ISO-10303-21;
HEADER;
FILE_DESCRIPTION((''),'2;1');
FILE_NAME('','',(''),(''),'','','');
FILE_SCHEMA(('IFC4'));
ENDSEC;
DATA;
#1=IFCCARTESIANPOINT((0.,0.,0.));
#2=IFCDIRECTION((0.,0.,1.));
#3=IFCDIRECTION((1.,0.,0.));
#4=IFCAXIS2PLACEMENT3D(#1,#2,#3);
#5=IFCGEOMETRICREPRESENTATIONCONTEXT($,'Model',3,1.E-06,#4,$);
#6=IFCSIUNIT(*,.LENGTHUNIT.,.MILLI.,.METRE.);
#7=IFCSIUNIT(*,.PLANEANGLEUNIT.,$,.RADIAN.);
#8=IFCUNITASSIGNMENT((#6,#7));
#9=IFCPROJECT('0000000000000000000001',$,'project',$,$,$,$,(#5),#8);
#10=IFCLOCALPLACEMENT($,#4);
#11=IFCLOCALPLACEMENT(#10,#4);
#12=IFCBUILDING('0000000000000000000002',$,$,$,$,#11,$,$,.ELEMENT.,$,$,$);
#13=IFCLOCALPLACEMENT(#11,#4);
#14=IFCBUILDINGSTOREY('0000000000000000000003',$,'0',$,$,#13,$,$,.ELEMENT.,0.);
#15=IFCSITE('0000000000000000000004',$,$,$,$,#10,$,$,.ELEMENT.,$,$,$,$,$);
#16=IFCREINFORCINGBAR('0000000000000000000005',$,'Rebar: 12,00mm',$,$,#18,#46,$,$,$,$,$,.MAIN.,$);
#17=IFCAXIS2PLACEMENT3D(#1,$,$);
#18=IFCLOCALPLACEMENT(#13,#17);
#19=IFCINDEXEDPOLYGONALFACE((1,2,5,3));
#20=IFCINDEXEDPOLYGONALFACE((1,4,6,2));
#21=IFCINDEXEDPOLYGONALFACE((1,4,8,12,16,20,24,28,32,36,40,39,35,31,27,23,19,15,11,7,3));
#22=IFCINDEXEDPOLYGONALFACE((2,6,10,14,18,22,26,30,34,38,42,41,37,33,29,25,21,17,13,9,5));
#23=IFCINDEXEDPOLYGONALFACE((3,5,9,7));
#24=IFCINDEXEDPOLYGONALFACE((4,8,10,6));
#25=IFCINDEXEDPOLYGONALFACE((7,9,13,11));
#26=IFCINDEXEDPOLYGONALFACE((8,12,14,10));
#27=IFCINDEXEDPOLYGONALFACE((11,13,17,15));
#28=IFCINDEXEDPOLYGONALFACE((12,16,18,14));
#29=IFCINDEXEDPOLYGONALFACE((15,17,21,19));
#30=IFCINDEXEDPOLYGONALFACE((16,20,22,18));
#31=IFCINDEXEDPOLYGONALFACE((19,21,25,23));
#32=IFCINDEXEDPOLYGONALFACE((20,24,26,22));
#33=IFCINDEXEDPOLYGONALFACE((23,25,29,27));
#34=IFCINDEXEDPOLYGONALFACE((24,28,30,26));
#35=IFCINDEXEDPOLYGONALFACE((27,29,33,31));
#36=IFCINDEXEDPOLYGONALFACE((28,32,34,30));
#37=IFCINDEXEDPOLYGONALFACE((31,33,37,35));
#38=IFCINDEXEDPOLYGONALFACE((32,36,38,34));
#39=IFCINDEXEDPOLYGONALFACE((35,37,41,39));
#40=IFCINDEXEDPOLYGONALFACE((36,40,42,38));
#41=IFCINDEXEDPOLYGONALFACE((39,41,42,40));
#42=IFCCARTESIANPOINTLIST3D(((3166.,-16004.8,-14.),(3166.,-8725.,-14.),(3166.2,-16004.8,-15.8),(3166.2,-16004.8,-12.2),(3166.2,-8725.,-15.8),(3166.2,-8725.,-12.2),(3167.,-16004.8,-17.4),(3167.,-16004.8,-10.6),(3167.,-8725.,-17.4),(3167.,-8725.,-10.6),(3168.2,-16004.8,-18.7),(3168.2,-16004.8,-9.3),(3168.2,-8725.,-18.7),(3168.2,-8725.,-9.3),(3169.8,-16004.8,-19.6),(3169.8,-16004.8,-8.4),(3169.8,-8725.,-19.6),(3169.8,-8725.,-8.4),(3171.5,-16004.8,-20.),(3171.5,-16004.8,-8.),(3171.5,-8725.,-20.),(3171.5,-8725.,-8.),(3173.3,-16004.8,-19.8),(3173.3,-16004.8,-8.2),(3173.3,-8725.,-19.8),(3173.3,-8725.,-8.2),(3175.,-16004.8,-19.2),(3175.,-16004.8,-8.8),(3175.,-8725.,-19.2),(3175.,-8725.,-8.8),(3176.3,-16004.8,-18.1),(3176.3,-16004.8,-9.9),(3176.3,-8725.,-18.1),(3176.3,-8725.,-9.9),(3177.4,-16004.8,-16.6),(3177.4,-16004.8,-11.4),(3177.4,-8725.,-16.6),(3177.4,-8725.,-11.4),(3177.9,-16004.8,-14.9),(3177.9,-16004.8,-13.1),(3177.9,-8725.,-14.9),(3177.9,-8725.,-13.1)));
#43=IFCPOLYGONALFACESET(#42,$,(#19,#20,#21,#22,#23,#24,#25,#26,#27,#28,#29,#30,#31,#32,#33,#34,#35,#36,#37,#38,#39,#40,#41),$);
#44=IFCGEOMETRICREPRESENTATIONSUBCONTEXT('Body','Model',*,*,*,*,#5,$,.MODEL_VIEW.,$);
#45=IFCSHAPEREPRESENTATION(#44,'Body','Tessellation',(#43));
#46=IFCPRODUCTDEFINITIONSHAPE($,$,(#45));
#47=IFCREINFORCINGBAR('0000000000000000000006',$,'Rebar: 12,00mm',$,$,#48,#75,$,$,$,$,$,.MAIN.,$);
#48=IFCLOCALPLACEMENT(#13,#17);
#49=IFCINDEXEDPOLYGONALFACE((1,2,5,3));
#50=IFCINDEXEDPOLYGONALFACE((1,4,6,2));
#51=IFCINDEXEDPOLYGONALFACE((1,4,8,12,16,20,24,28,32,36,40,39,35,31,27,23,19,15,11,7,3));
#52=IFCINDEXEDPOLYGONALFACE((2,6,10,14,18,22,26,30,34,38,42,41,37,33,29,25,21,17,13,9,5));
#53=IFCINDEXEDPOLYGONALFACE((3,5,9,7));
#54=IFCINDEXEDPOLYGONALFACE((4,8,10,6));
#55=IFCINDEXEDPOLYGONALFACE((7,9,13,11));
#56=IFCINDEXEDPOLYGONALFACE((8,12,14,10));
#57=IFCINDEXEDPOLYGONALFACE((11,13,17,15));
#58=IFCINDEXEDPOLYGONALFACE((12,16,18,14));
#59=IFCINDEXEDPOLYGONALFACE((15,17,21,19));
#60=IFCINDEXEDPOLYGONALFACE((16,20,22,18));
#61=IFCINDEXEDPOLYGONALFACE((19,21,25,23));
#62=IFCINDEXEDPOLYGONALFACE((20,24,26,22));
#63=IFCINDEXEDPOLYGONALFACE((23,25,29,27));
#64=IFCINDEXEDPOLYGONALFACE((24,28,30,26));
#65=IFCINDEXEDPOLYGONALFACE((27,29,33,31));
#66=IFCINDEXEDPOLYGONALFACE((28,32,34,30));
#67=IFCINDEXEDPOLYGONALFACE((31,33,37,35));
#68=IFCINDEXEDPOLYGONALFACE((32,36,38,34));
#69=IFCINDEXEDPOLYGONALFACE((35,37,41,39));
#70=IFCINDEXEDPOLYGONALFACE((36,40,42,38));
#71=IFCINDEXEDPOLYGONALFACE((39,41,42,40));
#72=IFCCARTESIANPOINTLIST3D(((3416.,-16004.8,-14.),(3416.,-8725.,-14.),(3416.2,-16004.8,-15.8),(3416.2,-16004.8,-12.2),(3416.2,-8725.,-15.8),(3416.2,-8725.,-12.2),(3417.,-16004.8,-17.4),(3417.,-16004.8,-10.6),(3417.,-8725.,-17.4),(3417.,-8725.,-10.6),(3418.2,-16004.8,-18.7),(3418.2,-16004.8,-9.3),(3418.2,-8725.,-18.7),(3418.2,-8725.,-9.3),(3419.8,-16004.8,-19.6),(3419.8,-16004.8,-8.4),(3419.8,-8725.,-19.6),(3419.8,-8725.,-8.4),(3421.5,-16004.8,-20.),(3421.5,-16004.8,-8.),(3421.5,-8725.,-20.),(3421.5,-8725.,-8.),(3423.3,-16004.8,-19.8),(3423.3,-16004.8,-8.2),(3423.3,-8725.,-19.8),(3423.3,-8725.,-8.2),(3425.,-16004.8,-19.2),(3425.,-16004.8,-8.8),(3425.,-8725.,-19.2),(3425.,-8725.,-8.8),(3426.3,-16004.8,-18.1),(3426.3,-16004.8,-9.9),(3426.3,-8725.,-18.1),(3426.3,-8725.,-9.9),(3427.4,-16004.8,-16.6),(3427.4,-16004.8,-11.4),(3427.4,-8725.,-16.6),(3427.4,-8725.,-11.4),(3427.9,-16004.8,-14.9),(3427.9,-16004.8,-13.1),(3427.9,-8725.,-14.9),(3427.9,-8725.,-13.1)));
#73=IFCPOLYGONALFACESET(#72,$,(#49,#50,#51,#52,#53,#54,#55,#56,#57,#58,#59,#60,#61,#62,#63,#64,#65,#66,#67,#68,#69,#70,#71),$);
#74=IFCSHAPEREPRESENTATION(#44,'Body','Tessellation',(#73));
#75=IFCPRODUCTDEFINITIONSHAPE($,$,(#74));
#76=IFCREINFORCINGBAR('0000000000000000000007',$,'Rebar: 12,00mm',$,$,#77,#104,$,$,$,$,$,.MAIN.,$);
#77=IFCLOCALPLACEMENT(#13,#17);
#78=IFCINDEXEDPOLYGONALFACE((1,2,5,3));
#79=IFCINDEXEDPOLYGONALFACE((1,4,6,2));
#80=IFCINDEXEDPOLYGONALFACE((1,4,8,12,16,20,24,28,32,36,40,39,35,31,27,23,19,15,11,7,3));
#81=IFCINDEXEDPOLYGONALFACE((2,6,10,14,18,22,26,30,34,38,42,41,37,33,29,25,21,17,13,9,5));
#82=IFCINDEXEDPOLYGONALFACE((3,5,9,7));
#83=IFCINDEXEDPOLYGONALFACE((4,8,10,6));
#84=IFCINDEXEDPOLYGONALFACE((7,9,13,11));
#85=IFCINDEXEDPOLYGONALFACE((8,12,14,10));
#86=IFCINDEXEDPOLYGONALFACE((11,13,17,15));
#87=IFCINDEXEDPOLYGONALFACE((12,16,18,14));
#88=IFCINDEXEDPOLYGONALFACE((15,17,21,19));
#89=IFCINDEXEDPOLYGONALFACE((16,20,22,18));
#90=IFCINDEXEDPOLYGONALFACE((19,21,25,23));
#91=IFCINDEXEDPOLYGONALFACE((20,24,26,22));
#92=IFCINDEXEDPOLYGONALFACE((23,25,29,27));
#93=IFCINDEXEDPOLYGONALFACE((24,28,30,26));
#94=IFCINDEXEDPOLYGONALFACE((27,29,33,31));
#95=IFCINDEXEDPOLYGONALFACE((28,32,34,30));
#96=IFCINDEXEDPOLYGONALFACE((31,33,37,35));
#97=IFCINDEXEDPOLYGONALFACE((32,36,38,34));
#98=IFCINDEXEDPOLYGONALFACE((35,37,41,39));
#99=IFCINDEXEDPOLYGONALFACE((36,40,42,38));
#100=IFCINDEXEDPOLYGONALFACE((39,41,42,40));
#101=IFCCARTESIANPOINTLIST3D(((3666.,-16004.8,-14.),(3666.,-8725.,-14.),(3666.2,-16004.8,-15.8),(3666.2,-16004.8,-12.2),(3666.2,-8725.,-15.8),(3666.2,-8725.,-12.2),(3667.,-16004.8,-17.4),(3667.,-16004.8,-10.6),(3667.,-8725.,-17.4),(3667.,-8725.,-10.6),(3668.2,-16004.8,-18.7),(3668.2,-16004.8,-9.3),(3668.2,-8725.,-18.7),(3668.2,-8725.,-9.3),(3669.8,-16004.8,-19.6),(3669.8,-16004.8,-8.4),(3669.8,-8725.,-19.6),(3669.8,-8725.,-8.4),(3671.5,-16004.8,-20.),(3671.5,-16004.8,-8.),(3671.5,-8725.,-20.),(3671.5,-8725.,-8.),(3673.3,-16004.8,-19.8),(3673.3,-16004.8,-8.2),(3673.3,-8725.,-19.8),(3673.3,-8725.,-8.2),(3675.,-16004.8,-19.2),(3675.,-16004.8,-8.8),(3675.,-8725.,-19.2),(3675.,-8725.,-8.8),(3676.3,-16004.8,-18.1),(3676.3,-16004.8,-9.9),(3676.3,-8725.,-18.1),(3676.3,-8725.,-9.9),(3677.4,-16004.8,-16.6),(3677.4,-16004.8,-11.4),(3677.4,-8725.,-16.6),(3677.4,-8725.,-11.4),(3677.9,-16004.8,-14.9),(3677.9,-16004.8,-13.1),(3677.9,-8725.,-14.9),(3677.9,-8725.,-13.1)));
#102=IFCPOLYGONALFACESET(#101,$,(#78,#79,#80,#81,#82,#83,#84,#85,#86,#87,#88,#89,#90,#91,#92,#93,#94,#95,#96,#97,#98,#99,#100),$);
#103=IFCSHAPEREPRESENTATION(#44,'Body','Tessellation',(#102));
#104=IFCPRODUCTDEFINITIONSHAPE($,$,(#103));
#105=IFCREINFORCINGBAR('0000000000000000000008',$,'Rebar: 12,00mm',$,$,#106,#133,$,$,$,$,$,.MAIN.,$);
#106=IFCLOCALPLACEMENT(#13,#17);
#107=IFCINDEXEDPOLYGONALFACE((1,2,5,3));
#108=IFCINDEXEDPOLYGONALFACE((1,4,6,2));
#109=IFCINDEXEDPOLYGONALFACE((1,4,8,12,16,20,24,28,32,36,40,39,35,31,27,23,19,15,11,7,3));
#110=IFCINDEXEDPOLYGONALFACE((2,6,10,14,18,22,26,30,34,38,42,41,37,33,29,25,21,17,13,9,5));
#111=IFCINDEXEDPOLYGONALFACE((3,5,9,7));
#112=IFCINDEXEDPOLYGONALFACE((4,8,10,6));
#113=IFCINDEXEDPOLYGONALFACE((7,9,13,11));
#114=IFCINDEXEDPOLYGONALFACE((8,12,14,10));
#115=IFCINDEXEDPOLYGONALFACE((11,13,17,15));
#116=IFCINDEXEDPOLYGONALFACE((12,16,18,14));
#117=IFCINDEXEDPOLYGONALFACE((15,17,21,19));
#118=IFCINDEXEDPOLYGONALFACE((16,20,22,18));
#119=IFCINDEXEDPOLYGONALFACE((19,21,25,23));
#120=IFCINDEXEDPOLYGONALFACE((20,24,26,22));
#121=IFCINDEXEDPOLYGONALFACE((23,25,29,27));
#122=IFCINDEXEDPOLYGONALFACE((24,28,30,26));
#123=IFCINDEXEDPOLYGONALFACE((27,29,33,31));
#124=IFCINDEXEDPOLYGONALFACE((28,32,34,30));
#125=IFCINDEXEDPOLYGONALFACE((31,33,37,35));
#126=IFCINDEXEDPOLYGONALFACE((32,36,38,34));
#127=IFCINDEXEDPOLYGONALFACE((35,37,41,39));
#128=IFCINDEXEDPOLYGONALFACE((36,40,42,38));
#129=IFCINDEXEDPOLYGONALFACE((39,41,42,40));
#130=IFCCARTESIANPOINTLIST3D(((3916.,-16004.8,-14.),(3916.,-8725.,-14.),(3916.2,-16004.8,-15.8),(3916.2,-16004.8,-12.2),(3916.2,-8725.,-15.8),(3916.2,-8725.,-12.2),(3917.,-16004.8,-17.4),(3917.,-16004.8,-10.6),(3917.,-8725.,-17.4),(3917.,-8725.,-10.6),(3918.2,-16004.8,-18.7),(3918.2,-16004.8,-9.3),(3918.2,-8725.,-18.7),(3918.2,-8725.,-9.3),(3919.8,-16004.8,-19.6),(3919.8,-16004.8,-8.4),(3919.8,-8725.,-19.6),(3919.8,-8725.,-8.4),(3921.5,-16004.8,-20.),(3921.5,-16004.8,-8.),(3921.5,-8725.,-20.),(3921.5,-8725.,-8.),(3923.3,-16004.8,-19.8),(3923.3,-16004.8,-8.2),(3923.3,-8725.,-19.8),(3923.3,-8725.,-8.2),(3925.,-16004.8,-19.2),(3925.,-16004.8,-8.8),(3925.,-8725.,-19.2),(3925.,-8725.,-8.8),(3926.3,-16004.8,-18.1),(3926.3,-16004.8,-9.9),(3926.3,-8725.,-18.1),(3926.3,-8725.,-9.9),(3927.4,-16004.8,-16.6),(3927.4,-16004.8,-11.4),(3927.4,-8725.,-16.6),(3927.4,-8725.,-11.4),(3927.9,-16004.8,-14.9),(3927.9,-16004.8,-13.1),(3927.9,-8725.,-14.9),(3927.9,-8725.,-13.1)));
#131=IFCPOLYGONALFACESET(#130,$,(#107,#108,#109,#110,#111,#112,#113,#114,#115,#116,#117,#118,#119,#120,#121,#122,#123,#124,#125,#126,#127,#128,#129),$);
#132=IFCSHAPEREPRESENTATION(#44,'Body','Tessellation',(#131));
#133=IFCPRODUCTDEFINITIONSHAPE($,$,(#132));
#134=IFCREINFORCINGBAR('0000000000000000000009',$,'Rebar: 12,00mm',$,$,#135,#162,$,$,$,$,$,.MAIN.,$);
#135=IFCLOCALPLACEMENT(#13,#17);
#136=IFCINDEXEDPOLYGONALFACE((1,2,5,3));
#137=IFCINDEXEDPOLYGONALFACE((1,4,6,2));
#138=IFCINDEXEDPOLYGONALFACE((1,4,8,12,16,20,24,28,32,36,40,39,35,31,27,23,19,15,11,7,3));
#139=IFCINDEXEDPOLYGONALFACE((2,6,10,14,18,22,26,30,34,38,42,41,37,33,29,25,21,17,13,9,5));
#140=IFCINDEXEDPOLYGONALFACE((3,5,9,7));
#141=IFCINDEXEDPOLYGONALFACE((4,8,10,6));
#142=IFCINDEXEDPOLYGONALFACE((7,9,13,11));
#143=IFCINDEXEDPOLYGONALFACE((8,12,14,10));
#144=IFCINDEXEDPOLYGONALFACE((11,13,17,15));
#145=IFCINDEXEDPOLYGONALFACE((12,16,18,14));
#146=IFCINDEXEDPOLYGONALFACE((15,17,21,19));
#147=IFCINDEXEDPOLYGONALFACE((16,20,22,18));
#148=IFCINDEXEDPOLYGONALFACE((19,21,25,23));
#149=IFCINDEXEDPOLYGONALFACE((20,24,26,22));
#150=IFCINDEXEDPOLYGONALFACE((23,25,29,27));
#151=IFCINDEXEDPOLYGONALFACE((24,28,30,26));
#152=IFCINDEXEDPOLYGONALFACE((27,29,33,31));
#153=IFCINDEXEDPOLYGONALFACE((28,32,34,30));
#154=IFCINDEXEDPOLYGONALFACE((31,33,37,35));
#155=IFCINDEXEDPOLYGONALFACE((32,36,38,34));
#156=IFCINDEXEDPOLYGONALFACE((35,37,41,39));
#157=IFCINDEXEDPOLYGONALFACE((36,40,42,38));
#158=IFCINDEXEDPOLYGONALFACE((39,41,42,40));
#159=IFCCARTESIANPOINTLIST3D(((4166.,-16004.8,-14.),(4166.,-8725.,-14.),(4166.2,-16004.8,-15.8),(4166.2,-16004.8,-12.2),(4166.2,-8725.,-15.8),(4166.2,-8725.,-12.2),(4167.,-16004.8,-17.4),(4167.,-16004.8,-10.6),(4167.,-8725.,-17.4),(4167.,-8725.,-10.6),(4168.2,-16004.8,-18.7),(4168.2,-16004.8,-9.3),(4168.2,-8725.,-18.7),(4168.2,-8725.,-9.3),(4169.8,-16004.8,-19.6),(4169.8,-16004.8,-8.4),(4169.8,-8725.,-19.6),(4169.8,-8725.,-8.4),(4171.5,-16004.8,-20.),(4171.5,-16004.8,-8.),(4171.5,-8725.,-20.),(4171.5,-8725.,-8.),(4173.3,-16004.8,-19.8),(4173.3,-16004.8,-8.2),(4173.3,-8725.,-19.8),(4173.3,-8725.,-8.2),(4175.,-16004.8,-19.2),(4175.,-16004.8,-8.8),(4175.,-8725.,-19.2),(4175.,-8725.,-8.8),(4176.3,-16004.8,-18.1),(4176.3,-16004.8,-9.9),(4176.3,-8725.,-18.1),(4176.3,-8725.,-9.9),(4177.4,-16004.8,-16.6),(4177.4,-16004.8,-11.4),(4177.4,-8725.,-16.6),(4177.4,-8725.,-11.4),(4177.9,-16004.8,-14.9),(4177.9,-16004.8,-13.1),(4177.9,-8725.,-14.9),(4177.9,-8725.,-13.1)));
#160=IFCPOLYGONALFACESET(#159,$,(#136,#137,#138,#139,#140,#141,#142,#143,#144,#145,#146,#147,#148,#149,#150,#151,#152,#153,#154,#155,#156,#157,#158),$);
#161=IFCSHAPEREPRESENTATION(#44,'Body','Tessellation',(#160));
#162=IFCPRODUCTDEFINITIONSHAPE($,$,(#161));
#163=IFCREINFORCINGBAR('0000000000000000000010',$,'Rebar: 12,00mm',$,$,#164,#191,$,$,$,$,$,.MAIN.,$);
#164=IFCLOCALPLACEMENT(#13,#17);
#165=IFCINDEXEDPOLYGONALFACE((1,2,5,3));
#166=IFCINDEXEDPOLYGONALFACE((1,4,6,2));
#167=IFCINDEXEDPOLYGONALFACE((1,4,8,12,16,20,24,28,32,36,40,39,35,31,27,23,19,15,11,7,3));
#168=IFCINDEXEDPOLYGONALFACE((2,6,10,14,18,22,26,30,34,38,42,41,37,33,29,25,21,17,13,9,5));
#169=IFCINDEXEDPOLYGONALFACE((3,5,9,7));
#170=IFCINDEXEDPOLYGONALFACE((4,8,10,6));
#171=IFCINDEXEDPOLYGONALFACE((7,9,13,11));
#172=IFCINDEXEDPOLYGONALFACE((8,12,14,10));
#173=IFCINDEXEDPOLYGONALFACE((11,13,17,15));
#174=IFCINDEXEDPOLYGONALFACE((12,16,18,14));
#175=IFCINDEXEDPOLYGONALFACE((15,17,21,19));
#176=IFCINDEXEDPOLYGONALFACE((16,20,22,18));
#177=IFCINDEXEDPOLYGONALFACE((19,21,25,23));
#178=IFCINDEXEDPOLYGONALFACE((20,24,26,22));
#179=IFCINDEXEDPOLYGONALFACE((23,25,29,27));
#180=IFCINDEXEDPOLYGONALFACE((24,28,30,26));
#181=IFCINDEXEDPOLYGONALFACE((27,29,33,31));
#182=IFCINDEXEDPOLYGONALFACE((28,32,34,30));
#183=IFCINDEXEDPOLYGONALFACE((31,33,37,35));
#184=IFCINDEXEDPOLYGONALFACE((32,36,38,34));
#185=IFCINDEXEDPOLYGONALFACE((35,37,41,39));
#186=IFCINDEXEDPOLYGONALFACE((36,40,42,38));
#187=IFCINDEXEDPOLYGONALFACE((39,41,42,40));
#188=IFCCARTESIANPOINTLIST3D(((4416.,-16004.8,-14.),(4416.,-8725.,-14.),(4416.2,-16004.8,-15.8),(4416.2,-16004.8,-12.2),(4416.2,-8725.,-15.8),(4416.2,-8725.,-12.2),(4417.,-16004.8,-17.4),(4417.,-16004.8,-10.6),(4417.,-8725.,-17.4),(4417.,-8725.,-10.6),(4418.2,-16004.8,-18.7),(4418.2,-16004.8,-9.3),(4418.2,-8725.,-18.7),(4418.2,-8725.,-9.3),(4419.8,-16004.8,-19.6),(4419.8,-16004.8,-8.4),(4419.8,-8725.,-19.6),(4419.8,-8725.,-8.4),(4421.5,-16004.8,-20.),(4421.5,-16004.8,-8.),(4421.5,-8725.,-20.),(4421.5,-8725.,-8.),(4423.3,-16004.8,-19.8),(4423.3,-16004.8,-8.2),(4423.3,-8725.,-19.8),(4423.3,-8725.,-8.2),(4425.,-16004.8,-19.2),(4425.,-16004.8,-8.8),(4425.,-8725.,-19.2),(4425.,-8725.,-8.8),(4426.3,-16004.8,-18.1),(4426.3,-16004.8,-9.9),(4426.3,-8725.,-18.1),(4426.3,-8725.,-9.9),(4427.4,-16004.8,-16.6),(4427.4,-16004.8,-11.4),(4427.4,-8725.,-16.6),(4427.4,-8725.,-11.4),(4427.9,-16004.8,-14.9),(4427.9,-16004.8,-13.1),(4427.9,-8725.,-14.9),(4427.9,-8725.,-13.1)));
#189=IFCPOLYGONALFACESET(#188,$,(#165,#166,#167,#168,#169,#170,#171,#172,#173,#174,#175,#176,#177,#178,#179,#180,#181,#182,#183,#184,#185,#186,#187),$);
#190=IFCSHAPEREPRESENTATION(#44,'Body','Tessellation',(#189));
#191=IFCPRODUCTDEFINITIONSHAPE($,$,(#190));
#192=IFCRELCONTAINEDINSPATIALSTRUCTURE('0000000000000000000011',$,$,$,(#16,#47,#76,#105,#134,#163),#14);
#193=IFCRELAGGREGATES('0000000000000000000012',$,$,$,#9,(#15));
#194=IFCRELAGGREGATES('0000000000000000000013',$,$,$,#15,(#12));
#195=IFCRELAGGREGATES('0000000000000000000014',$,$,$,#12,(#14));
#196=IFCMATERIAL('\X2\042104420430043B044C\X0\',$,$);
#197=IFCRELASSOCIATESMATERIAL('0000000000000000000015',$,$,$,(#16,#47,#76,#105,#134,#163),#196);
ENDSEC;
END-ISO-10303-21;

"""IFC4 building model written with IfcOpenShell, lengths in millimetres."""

from ifc_helpers import new_model, entity, si_unit, origin_with_axes, place, context, subcontext, project, spatial, source, transform, mapped, material, element, save


model = new_model("IFC4")

# Units and contexts
model_context = context("Model", 3, precision=1e-06, world=origin_with_axes())
body_context = subcontext(model_context, "Body", "Model", "MODEL_VIEW")
ifc_project = project(units=[si_unit("LENGTHUNIT", "METRE", prefix="MILLI"), si_unit("PLANEANGLEUNIT", "RADIAN")], contexts=[model_context])

# Site, building, storey
site_placement = place(None, origin_with_axes())
site = spatial("IfcSite", under=ifc_project, at=site_placement, CompositionType="ELEMENT")
building_placement = place(site_placement, origin_with_axes())
building = spatial("IfcBuilding", under=site, at=building_placement, CompositionType="ELEMENT")
storey_placement = place(building_placement, origin_with_axes())
storey = spatial("IfcBuildingStorey", under=building, at=storey_placement, Name="0", CompositionType="ELEMENT", Elevation=0.0)

# Reinforcing bars
ifc_material = material(Name="Сталь")
shared_shape = source(origin_with_axes(), body_context, "Body", "AdvancedSweptSolid", [
    entity("IfcSweptDiskSolid", entity("IfcIndexedPolyCurve", entity("IfcCartesianPointList3D", [[0.0, 0.0, 0.0], [7279.8, 0.0, 0.0]]), [entity("IfcLineIndex", [1, 2])]), 6.0),
])
reinforcing_bar_1_placement = place(storey_placement, origin_with_axes())
element("IfcReinforcingBar", 1, at=reinforcing_bar_1_placement, inside=storey, material=ifc_material, Name="Rebar: 12,00mm", PredefinedType="MAIN", context=body_context, shape_type="MappedRepresentation", body=[
    mapped(shared_shape, transform((3172.0, -16004.8, -14.0), x_axis=(0.0, 1.0, 0.0), y_axis=(-1.0, 0.0, 0.0), z_axis=(0.0, 0.0, 1.0), scale=1.0)),
])
reinforcing_bar_2_placement = place(storey_placement, origin_with_axes())
element("IfcReinforcingBar", 2, at=reinforcing_bar_2_placement, inside=storey, material=ifc_material, Name="Rebar: 12,00mm", PredefinedType="MAIN", context=body_context, shape_type="MappedRepresentation", body=[
    mapped(shared_shape, transform((3422.0, -16004.8, -14.0), x_axis=(0.0, 1.0, 0.0), y_axis=(-1.0, 0.0, 0.0), z_axis=(0.0, 0.0, 1.0), scale=1.0)),
])
reinforcing_bar_3_placement = place(storey_placement, origin_with_axes())
element("IfcReinforcingBar", 3, at=reinforcing_bar_3_placement, inside=storey, material=ifc_material, Name="Rebar: 12,00mm", PredefinedType="MAIN", context=body_context, shape_type="MappedRepresentation", body=[
    mapped(shared_shape, transform((3672.0, -16004.8, -14.0), x_axis=(0.0, 1.0, 0.0), y_axis=(-1.0, 0.0, 0.0), z_axis=(0.0, 0.0, 1.0), scale=1.0)),
])
reinforcing_bar_4_placement = place(storey_placement, origin_with_axes())
element("IfcReinforcingBar", 4, at=reinforcing_bar_4_placement, inside=storey, material=ifc_material, Name="Rebar: 12,00mm", PredefinedType="MAIN", context=body_context, shape_type="MappedRepresentation", body=[
    mapped(shared_shape, transform((3922.0, -16004.8, -14.0), x_axis=(0.0, 1.0, 0.0), y_axis=(-1.0, 0.0, 0.0), z_axis=(0.0, 0.0, 1.0), scale=1.0)),
])
reinforcing_bar_5_placement = place(storey_placement, origin_with_axes())
element("IfcReinforcingBar", 5, at=reinforcing_bar_5_placement, inside=storey, material=ifc_material, Name="Rebar: 12,00mm", PredefinedType="MAIN", context=body_context, shape_type="MappedRepresentation", body=[
    mapped(shared_shape, transform((4172.0, -16004.8, -14.0), x_axis=(0.0, 1.0, 0.0), y_axis=(-1.0, 0.0, 0.0), z_axis=(0.0, 0.0, 1.0), scale=1.0)),
])
reinforcing_bar_6_placement = place(storey_placement, origin_with_axes())
element("IfcReinforcingBar", 6, at=reinforcing_bar_6_placement, inside=storey, material=ifc_material, Name="Rebar: 12,00mm", PredefinedType="MAIN", context=body_context, shape_type="MappedRepresentation", body=[
    mapped(shared_shape, transform((4422.0, -16004.8, -14.0), x_axis=(0.0, 1.0, 0.0), y_axis=(-1.0, 0.0, 0.0), z_axis=(0.0, 0.0, 1.0), scale=1.0)),
])

save(model, "model.ifc")
